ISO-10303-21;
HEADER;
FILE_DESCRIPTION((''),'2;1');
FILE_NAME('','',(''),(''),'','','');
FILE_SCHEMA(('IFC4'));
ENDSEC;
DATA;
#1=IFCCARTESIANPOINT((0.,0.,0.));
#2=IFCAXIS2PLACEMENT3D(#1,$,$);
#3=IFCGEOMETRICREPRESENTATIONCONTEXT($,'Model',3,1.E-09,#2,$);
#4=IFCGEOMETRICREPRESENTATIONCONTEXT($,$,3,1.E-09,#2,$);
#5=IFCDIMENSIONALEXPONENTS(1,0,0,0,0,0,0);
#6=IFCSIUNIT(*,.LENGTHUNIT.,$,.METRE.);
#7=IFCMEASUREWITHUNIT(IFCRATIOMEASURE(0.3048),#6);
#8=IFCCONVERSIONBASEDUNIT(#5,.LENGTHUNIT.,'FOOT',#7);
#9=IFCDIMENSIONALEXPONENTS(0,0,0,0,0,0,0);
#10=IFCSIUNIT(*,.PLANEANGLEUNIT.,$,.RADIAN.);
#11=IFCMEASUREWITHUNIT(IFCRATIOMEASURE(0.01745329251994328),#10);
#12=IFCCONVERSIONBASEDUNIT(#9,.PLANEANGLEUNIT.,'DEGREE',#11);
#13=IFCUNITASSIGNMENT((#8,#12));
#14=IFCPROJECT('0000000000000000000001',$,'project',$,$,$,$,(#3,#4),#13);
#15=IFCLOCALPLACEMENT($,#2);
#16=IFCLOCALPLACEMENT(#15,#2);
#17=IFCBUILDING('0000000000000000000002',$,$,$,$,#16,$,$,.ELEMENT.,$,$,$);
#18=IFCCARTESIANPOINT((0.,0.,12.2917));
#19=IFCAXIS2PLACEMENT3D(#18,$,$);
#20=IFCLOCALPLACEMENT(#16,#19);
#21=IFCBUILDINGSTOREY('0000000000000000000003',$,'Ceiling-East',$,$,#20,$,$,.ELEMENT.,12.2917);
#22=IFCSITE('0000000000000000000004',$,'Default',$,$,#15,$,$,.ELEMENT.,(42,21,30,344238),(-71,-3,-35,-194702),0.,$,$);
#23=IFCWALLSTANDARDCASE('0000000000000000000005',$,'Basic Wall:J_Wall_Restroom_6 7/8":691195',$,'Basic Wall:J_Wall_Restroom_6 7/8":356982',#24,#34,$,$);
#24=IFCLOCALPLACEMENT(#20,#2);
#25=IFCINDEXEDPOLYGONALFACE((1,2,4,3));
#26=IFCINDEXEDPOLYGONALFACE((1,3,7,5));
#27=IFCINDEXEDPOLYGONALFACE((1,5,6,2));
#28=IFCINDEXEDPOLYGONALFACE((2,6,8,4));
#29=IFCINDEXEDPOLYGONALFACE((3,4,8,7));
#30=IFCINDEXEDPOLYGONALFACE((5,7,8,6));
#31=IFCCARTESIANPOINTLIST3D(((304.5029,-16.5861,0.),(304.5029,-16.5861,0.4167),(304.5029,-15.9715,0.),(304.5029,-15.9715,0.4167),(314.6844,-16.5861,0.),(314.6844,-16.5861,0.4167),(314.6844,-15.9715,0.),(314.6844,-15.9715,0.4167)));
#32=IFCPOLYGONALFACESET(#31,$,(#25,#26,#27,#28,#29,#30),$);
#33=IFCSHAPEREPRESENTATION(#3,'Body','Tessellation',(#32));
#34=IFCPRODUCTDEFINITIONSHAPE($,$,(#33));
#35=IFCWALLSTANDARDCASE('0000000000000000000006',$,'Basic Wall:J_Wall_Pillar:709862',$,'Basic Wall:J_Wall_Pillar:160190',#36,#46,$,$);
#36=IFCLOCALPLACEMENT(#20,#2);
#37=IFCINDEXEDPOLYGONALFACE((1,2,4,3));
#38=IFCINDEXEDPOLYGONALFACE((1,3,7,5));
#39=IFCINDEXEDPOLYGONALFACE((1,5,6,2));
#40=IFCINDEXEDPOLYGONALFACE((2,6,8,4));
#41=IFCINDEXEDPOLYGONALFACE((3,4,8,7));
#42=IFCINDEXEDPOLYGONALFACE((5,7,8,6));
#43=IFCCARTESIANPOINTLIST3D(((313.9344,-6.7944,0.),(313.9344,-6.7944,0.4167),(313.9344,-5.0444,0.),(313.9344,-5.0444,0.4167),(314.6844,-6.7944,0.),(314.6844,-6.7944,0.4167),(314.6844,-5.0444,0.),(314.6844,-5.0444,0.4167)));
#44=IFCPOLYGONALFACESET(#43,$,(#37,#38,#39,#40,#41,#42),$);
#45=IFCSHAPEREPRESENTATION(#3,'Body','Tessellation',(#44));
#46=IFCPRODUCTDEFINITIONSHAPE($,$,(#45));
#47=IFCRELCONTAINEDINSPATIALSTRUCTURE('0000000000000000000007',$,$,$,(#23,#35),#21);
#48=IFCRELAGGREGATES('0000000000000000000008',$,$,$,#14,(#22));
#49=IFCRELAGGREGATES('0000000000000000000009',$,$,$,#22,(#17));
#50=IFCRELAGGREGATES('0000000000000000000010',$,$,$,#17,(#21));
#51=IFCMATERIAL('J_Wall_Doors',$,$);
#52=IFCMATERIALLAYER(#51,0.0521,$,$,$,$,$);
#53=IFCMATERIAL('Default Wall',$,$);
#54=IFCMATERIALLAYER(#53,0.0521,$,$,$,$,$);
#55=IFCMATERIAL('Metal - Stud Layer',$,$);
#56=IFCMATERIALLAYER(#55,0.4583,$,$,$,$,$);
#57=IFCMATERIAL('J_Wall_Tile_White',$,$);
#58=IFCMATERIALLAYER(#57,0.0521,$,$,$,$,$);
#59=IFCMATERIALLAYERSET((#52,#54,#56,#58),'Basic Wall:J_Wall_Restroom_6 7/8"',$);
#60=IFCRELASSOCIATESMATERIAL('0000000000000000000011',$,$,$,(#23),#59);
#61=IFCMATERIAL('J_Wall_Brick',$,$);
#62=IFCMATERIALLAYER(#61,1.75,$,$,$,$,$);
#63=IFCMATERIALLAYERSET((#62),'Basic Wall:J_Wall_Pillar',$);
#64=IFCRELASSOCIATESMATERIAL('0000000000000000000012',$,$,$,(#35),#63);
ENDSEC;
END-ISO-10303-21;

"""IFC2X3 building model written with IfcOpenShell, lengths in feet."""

from ifc_helpers import new_model, entity, si_unit, converted_unit, frame, frame_2d, origin, place, context, project, spatial, rectangle, extrude, clip, halfspace, material, layer, layer_set, layer_usage, element, save


model = new_model("IFC2X3")

# Units and contexts
model_context = context("Model", 3, precision=1e-09, world=origin())
context_of_model = context(None, 3, precision=1e-09, world=origin())
ifc_project = project(units=[converted_unit("LENGTHUNIT", "FOOT", entity("IfcRatioMeasure", 0.3048), si_unit("LENGTHUNIT", "METRE"), dimensions=[1, 0, 0, 0, 0, 0, 0]), converted_unit("PLANEANGLEUNIT", "DEGREE", entity("IfcRatioMeasure", 0.01745329251994328), si_unit("PLANEANGLEUNIT", "RADIAN"), dimensions=[0, 0, 0, 0, 0, 0, 0])], contexts=[model_context, context_of_model])

# Site, building, storey
site_placement = place(None, origin())
site = spatial("IfcSite", under=ifc_project, at=site_placement, Name="Default", CompositionType="ELEMENT", RefLatitude=(42, 21, 30, 344238), RefLongitude=(-71, -3, -35, -194702), RefElevation=0.0)
building_placement = place(site_placement, origin())
building = spatial("IfcBuilding", under=site, at=building_placement, CompositionType="ELEMENT")
storey_placement = place(building_placement, frame((0.0, 0.0, 12.2917)))
storey = spatial("IfcBuildingStorey", under=building, at=storey_placement, Name="Ceiling-East", CompositionType="ELEMENT", Elevation=12.2917)

# Shared definitions
ifc_material_1 = material(Name="J_Wall_Brick")

# Shared definitions
ifc_layer_1 = layer(ifc_material_1, 1.75)
ifc_layer_set_1 = layer_set([ifc_layer_1], Name="Basic Wall:J_Wall_Pillar")
ifc_material_2 = material(Name="J_Wall_Doors")
ifc_layer_2 = layer(ifc_material_2, 0.0521)
ifc_material_3 = material(Name="Default Wall")
ifc_layer_3 = layer(ifc_material_3, 0.0521)
ifc_material_4 = material(Name="Metal - Stud Layer")
ifc_layer_4 = layer(ifc_material_4, 0.4583)
ifc_material_5 = material(Name="J_Wall_Tile_White")
ifc_layer_5 = layer(ifc_material_5, 0.0521)
ifc_layer_set_2 = layer_set([ifc_layer_2, ifc_layer_3, ifc_layer_4, ifc_layer_5], Name="Basic Wall:J_Wall_Restroom_6 7/8\"")

# Walls
ifc_layer_usage_1 = layer_usage(ifc_layer_set_2, "AXIS2", "POSITIVE", -0.3073)
wall_1_placement = place(storey_placement, frame((314.6844, -16.2788, 0.0), z_axis=(0.0, 0.0, 1.0), x_axis=(-1.0, 0.0, 0.0)))
element("IfcWallStandardCase", 1, at=wall_1_placement, inside=storey, material=ifc_layer_usage_1, Name="Basic Wall:J_Wall_Restroom_6 7/8\":691195", ObjectType="Basic Wall:J_Wall_Restroom_6 7/8\":356982", context=model_context, shape_type="Clipping", body=[
    clip(extrude(rectangle(XDim=10.1815, YDim=0.6146, at=frame_2d((5.0907, 0.0), x_axis=(-1.0, 0.0))), origin(), (0.0, 0.0, 1.0), 0.4167), halfspace(frame((0.0, 0.0, -12.125)), True)),
])
ifc_layer_usage_2 = layer_usage(ifc_layer_set_1, "AXIS2", "NEGATIVE", 0.875)
wall_2_placement = place(storey_placement, frame((314.6844, -5.9194, 0.0), z_axis=(0.0, 0.0, 1.0), x_axis=(-1.0, 0.0, 0.0)))
element("IfcWallStandardCase", 2, at=wall_2_placement, inside=storey, material=ifc_layer_usage_2, Name="Basic Wall:J_Wall_Pillar:709862", ObjectType="Basic Wall:J_Wall_Pillar:160190", context=model_context, shape_type="Clipping", body=[
    clip(extrude(rectangle(XDim=0.75, YDim=1.75, at=frame_2d((0.375, 0.0), x_axis=(-1.0, 0.0))), origin(), (0.0, 0.0, 1.0), 0.4167), halfspace(frame((0.0, 0.0, -12.125)), True)),
])

save(model, "model.ifc")
